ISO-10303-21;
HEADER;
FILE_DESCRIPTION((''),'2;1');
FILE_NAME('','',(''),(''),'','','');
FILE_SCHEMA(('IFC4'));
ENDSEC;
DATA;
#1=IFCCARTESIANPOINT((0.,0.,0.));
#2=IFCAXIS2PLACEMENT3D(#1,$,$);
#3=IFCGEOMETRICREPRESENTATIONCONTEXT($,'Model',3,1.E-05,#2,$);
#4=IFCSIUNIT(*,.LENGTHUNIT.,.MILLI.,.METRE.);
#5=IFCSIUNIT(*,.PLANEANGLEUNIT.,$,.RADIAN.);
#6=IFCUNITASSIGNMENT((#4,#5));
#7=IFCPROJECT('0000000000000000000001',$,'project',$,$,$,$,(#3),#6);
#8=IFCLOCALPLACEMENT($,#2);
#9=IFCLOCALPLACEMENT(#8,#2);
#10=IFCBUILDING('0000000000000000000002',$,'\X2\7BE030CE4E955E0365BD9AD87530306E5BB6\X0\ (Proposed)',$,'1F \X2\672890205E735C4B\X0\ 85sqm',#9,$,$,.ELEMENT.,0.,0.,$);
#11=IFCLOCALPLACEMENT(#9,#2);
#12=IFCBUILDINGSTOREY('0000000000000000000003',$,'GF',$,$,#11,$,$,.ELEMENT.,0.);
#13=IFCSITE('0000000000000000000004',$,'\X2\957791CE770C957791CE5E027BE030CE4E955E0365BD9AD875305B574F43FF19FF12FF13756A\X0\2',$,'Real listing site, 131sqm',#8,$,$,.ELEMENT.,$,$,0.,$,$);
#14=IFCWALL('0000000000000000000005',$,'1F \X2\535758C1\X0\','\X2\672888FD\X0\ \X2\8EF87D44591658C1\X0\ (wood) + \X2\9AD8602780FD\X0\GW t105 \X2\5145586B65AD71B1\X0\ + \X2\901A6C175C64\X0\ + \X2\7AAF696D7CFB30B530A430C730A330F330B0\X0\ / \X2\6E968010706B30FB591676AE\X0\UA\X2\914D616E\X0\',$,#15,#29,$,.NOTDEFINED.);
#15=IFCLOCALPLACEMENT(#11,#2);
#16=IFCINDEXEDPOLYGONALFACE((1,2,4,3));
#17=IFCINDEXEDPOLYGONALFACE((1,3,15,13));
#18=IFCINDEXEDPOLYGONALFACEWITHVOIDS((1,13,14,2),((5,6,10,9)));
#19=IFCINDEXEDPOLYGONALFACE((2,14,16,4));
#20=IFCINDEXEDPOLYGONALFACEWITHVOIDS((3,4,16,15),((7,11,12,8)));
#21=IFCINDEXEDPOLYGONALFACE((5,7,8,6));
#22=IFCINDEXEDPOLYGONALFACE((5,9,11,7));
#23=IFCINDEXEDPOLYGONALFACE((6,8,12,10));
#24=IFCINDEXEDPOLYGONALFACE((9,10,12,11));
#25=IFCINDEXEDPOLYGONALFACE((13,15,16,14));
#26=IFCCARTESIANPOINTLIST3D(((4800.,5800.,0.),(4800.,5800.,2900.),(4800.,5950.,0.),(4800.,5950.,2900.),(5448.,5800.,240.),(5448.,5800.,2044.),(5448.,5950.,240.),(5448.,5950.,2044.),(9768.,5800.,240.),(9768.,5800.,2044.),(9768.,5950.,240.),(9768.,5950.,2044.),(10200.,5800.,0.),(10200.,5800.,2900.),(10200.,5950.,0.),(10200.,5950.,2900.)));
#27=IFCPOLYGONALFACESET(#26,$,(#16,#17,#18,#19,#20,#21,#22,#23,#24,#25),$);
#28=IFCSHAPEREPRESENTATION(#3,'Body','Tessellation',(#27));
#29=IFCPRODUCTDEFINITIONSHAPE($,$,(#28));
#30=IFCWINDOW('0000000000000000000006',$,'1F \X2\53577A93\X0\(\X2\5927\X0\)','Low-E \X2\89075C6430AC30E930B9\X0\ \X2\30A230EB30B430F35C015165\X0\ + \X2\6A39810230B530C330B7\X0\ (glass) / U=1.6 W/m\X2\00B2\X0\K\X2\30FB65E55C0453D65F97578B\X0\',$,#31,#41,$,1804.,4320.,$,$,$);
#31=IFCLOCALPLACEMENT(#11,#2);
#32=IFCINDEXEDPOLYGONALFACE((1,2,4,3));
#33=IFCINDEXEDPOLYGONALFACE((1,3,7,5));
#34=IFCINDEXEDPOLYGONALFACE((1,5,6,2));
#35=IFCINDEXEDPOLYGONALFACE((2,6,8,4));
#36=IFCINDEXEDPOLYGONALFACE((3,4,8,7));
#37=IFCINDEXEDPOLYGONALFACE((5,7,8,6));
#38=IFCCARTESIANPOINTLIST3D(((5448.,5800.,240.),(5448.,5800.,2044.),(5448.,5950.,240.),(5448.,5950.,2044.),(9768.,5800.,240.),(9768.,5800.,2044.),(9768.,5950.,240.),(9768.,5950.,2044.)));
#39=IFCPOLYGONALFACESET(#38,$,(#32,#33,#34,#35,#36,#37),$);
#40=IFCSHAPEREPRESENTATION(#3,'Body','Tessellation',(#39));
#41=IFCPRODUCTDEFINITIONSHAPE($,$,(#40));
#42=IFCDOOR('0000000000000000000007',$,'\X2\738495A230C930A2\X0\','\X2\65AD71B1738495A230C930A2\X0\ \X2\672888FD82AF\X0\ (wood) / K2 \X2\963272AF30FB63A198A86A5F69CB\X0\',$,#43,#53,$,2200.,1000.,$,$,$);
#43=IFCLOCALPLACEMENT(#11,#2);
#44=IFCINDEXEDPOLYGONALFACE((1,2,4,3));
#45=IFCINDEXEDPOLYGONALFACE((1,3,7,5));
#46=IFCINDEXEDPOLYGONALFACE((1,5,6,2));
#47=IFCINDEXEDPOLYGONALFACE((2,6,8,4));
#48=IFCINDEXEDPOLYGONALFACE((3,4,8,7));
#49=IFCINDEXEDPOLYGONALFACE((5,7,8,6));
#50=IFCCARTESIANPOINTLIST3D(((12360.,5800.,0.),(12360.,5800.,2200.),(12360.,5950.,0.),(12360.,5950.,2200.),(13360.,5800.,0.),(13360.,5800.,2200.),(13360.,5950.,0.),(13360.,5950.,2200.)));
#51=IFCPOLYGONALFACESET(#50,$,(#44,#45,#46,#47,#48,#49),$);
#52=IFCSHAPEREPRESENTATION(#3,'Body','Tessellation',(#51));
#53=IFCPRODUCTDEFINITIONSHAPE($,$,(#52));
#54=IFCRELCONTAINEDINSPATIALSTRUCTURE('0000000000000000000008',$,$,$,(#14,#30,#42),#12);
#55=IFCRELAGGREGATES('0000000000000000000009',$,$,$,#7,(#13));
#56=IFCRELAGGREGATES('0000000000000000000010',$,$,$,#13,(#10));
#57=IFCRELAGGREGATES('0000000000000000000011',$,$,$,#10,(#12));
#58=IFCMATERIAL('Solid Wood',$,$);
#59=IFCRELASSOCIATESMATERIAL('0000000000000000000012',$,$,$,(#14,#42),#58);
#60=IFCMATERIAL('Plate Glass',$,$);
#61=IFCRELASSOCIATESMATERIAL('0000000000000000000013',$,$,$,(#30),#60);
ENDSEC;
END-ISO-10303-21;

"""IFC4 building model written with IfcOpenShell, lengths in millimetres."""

from ifc_helpers import new_model, si_unit, frame, frame_2d, origin, place, context, project, spatial, rectangle, extrude, material, element, fill, save


model = new_model("IFC4")

# Units and contexts
model_context = context("Model", 3, precision=1e-05, world=origin())
ifc_project = project(units=[si_unit("LENGTHUNIT", "METRE", prefix="MILLI"), si_unit("PLANEANGLEUNIT", "RADIAN")], contexts=[model_context])

# Site, building, storey
site_placement = place(None, origin())
site = spatial("IfcSite", under=ifc_project, at=site_placement, Name="長野県長野市篠ノ井布施高田字佃９２３番2", ObjectType="Real listing site, 131sqm", CompositionType="ELEMENT", RefElevation=0.0)
building_placement = place(site_placement, origin())
building = spatial("IfcBuilding", under=site, at=building_placement, Name="篠ノ井布施高田の家 (Proposed)", ObjectType="1F 木造平屋 85sqm", CompositionType="ELEMENT", ElevationOfRefHeight=0.0, ElevationOfTerrain=0.0)
storey_placement = place(building_placement, origin())
storey = spatial("IfcBuildingStorey", under=building, at=storey_placement, Name="GF", CompositionType="ELEMENT", Elevation=0.0)

# Shared definitions
ifc_material_1 = material(Name="Solid Wood")

# Wall, openings, window, door
wall_1_placement = place(storey_placement, frame((2400.0, 2900.0, 0.0)))
wall_1 = element("IfcWall", 1, at=wall_1_placement, inside=storey, material=ifc_material_1, Name="1F 南壁", Description="木製 軸組外壁 (wood) + 高性能GW t105 充填断熱 + 通気層 + 窯業系サイディング / 準耐火・外皮UA配慮", PredefinedType="NOTDEFINED", context=model_context, shape_type="SweptSolid", body=[
    extrude(rectangle(XDim=5400.0, YDim=150.0, at=frame_2d((2700.0, 75.0))), frame((2400.0, 2900.0, 0.0)), (0.0, 0.0, 1.0), 2900.0),
])
opening_1_placement = place(storey_placement, frame((2724.0, 2900.0, 120.0)))
opening_1 = element("IfcOpeningElement", 2, at=opening_1_placement, cuts=wall_1, PredefinedType="NOTDEFINED", context=model_context, shape_type="SweptSolid", body=[
    extrude(rectangle(XDim=4320.0, YDim=150.0, at=frame_2d((2160.0, 75.0))), frame((2724.0, 2900.0, 120.0)), (0.0, 0.0, 1.0), 1804.0),
])
opening_2_placement = place(storey_placement, frame((6180.0, 2900.0, 0.0)))
opening_2 = element("IfcOpeningElement", 3, at=opening_2_placement, cuts=wall_1, PredefinedType="NOTDEFINED", context=model_context, shape_type="SweptSolid", body=[
    extrude(rectangle(XDim=1000.0, YDim=150.0, at=frame_2d((500.0, 75.0))), frame((6180.0, 2900.0, 0.0)), (0.0, 0.0, 1.0), 2200.0),
])
ifc_material_2 = material(Name="Plate Glass")
window_1_placement = place(storey_placement, frame((2724.0, 2900.0, 120.0)))
window_1 = element("IfcWindow", 4, at=window_1_placement, inside=storey, material=ifc_material_2, Name="1F 南窓(大)", Description="Low-E 複層ガラス アルゴン封入 + 樹脂サッシ (glass) / U=1.6 W/m²K・日射取得型", OverallHeight=1804.0, OverallWidth=4320.0, context=model_context, shape_type="SweptSolid", body=[
    extrude(rectangle(XDim=4320.0, YDim=150.0, at=frame_2d((2160.0, 75.0))), frame((2724.0, 2900.0, 120.0)), (0.0, 0.0, 1.0), 1804.0),
])
fill(opening_1, window_1)
door_placement = place(storey_placement, frame((6180.0, 2900.0, 0.0)))
door = element("IfcDoor", 5, at=door_placement, inside=storey, material=ifc_material_1, Name="玄関ドア", Description="断熱玄関ドア 木製芯 (wood) / K2 防犯・採風機構", OverallHeight=2200.0, OverallWidth=1000.0, context=model_context, shape_type="SweptSolid", body=[
    extrude(rectangle(XDim=1000.0, YDim=150.0, at=frame_2d((500.0, 75.0))), frame((6180.0, 2900.0, 0.0)), (0.0, 0.0, 1.0), 2200.0),
])
fill(opening_2, door)

save(model, "model.ifc")
